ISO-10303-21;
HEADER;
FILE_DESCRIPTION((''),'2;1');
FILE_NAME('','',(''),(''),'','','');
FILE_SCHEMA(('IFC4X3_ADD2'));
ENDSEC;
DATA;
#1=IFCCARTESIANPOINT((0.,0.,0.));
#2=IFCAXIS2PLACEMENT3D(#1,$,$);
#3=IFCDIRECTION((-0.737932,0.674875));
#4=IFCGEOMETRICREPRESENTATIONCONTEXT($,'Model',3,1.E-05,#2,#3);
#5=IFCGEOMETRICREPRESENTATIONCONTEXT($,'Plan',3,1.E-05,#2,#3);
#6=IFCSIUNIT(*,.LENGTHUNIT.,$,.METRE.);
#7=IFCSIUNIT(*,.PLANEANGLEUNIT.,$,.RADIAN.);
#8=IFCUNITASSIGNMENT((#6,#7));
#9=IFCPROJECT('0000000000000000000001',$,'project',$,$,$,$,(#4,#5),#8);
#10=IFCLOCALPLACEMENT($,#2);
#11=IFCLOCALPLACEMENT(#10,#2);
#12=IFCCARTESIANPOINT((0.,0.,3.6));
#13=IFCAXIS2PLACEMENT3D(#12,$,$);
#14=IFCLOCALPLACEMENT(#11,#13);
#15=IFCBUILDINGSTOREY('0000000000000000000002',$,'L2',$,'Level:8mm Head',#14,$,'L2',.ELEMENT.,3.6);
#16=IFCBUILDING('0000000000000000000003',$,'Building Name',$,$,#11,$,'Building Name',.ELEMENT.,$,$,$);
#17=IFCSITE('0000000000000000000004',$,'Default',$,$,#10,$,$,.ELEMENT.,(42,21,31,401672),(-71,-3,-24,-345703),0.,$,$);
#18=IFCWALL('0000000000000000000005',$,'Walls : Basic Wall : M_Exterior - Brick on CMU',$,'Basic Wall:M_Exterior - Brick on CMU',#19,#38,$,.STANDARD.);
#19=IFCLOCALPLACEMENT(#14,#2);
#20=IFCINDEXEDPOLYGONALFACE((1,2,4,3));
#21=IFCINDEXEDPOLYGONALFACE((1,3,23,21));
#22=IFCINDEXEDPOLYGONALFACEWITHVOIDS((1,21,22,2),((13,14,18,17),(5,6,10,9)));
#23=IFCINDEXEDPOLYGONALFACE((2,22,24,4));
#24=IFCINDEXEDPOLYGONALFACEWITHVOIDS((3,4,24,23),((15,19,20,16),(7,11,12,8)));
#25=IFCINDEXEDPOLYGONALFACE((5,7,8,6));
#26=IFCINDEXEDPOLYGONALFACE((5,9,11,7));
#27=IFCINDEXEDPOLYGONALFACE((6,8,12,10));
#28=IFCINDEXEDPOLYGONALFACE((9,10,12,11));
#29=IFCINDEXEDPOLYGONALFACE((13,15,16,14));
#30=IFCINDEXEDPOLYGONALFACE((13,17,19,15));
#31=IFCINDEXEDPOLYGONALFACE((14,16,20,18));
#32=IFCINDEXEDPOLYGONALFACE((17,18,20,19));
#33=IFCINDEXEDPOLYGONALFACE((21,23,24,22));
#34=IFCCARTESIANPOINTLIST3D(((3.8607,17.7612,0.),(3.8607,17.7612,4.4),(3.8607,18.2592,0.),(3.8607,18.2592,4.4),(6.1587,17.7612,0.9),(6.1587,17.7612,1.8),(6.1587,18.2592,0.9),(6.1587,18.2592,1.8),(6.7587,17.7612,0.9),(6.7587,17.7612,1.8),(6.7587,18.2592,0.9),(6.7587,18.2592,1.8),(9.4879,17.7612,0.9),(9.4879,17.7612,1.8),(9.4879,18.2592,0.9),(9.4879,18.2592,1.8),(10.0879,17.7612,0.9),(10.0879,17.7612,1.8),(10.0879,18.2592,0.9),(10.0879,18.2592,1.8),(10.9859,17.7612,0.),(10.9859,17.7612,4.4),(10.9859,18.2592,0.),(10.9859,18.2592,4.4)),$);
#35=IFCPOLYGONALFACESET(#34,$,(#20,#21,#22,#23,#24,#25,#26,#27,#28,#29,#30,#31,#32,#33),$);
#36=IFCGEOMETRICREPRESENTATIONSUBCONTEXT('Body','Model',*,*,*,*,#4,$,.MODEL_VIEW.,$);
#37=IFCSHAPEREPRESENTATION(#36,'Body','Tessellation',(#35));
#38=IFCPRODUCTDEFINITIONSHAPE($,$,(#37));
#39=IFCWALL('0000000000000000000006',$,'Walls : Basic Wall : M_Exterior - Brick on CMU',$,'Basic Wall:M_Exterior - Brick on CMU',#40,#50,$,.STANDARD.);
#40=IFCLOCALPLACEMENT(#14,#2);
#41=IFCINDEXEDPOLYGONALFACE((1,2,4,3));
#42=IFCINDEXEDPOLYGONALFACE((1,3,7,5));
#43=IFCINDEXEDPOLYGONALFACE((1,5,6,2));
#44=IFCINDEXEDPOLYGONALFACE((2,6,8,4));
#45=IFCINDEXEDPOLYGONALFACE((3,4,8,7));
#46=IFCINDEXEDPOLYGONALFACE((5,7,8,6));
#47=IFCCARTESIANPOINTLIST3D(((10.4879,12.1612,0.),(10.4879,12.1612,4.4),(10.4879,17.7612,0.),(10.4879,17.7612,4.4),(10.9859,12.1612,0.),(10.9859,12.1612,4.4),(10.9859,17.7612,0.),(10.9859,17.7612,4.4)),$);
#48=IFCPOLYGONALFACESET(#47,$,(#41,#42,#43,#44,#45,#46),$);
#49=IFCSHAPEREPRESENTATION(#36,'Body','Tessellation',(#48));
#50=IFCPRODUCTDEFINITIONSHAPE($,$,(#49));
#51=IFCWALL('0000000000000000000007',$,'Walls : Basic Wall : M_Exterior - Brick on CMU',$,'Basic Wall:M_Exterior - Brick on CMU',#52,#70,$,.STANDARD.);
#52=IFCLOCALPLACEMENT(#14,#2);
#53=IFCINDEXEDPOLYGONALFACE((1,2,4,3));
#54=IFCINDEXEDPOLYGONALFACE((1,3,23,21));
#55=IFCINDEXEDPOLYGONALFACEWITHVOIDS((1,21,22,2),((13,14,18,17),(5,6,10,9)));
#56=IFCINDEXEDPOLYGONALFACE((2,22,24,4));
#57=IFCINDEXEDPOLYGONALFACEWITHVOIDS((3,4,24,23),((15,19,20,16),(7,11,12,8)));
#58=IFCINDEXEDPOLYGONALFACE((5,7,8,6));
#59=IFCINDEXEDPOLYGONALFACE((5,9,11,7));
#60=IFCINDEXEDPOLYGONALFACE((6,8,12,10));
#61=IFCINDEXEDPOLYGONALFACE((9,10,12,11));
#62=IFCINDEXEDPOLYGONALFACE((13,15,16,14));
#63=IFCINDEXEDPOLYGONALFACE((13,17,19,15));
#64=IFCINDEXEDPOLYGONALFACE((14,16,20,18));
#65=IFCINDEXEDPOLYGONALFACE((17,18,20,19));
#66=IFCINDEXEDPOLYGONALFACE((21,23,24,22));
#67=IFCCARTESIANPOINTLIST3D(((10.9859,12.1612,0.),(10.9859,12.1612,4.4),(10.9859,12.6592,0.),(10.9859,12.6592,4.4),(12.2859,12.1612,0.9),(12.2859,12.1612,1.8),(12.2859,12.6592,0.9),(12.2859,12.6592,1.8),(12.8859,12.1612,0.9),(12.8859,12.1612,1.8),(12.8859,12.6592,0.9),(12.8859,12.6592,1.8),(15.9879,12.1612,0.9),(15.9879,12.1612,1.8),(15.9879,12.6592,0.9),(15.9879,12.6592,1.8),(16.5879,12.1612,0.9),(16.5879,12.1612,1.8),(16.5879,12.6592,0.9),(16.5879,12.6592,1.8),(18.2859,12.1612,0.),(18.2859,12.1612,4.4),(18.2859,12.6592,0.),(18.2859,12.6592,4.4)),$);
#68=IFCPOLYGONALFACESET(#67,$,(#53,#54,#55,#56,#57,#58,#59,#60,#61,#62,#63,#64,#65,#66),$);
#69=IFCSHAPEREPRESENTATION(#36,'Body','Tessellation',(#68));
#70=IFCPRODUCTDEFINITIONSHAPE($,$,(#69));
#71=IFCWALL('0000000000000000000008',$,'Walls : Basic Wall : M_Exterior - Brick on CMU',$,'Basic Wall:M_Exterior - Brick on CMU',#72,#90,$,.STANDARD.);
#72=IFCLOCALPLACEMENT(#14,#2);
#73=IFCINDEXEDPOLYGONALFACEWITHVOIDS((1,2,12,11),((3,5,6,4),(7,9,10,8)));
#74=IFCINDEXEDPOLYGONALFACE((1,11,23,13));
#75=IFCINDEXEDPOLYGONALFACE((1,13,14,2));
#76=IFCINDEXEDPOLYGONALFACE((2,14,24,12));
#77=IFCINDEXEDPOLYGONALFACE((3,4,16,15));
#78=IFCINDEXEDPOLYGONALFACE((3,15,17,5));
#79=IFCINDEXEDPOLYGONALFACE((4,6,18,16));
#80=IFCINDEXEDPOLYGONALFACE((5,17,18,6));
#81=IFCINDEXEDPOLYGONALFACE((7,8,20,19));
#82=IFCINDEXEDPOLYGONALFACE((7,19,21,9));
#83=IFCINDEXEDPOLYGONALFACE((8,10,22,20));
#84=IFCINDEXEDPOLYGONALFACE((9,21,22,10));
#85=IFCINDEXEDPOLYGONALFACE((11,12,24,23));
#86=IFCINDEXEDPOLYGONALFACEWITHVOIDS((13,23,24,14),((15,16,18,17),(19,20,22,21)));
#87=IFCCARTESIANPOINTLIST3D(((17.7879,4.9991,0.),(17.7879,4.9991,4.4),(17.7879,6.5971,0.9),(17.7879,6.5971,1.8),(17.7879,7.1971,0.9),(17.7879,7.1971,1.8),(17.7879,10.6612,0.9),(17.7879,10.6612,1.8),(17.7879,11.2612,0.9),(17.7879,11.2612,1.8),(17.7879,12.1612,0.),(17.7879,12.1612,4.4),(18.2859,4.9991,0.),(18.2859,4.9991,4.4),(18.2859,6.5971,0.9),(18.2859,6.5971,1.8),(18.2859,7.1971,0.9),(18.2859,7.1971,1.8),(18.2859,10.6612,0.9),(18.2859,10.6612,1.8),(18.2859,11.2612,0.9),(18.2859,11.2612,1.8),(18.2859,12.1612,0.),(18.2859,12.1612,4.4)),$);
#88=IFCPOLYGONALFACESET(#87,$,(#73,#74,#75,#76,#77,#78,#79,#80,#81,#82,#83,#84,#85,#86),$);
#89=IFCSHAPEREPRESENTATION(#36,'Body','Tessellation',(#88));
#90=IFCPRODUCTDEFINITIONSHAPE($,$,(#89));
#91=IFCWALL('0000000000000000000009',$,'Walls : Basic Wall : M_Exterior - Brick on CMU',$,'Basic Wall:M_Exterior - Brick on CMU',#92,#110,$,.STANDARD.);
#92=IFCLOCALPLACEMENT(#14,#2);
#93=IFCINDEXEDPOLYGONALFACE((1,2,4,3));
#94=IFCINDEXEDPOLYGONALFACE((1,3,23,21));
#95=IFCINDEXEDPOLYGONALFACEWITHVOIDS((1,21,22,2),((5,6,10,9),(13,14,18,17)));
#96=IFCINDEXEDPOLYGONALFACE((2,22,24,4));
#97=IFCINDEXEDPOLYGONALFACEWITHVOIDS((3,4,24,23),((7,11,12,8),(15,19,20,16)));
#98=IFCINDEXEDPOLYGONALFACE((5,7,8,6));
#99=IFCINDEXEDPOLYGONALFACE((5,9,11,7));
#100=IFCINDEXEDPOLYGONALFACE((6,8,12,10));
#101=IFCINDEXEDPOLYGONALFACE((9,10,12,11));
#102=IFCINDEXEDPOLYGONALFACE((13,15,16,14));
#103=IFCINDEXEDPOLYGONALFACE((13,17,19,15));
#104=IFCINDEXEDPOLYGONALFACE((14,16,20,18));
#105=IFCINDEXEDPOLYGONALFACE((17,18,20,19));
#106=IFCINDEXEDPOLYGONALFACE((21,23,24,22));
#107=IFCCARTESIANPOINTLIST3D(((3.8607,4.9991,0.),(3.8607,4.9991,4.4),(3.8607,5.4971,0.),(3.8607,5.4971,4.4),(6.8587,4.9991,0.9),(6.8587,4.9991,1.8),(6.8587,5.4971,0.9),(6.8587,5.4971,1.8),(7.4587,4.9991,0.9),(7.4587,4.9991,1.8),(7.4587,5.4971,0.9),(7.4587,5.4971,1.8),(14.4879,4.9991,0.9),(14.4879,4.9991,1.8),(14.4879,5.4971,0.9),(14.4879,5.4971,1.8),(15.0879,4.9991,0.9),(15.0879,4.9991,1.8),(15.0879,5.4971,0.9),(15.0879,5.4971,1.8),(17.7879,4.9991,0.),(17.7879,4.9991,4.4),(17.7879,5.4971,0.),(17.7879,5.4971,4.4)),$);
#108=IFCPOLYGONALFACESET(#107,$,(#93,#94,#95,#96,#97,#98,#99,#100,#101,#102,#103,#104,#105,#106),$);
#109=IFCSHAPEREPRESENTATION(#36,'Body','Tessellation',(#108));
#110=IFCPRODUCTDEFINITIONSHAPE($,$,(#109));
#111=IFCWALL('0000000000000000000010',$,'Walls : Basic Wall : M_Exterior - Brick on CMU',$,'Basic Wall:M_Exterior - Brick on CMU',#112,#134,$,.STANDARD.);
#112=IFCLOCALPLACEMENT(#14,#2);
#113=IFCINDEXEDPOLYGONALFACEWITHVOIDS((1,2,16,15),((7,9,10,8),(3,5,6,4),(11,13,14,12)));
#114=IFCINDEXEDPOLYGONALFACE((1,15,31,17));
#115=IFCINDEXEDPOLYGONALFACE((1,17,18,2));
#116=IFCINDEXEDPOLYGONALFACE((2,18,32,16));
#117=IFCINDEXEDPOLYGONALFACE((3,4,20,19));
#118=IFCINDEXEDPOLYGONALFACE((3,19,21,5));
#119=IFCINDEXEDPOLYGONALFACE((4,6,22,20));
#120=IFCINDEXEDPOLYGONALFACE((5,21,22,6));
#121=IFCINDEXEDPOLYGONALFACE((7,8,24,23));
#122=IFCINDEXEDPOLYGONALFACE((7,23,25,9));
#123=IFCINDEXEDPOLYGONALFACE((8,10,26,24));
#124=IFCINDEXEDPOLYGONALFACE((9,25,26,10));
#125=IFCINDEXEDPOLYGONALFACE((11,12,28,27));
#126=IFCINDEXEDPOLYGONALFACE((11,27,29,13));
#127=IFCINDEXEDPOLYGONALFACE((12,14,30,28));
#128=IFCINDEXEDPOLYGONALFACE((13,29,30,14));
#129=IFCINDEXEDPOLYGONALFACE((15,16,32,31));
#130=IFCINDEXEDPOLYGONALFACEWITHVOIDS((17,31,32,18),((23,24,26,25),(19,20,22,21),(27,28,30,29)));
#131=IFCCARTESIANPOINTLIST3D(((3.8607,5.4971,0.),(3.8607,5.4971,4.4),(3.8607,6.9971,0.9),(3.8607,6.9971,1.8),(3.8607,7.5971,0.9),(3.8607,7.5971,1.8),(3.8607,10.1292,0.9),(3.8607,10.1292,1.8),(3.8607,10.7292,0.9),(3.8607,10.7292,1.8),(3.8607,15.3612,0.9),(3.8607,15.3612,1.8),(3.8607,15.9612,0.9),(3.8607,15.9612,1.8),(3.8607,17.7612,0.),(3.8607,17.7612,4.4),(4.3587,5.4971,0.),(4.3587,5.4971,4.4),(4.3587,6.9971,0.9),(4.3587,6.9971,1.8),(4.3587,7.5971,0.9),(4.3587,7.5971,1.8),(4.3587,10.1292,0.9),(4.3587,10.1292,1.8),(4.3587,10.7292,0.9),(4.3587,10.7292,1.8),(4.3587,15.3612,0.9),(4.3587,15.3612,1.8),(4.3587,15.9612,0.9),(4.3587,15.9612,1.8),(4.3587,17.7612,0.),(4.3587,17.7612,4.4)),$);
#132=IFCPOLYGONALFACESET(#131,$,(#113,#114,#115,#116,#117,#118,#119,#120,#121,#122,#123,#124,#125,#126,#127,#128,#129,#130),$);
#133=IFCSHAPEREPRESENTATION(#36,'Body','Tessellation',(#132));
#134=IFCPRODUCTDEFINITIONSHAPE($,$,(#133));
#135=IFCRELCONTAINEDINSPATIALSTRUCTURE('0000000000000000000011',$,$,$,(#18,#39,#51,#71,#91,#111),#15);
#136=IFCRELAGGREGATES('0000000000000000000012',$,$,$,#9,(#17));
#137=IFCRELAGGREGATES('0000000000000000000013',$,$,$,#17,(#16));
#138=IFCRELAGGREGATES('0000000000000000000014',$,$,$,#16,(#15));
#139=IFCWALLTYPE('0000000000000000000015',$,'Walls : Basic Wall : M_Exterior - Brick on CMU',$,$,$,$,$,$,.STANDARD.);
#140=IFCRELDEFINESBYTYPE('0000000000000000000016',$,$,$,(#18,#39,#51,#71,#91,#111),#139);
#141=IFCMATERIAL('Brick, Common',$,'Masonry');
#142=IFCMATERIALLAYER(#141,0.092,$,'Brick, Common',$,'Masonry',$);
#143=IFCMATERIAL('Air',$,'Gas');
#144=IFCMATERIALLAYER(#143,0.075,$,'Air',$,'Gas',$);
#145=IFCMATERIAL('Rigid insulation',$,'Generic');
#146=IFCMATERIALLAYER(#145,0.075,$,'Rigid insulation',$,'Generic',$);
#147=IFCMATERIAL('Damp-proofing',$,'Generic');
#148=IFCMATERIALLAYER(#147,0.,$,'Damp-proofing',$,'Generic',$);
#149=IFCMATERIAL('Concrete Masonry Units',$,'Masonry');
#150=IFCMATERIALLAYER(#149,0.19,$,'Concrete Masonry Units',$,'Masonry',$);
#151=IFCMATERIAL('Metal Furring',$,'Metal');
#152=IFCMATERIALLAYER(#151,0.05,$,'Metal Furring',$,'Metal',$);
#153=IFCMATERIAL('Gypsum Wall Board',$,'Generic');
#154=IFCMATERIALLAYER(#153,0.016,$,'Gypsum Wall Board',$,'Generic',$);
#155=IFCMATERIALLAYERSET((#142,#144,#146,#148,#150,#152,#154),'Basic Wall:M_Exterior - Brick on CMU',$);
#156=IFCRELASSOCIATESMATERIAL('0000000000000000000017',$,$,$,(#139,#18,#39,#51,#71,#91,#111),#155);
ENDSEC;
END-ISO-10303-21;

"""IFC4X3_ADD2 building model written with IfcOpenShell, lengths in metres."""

from ifc_helpers import new_model, si_unit, direction, frame, frame_2d, origin, place, context, subcontext, project, spatial, rectangle, extrude, material, layer, layer_set, type_object, element, save


model = new_model("IFC4X3_ADD2")

# Units and contexts
model_context = context("Model", 3, precision=1e-05, world=origin(), true_north=direction((-0.737932, 0.674875)))
plan_context = context("Plan", 3, precision=1e-05, world=origin(), true_north=direction((-0.737932, 0.674875)))
body_context = subcontext(model_context, "Body", "Model", "MODEL_VIEW")
ifc_project = project(units=[si_unit("LENGTHUNIT", "METRE"), si_unit("PLANEANGLEUNIT", "RADIAN")], contexts=[model_context, plan_context])

# Site, building, storey
site_placement = place(None, origin())
site = spatial("IfcSite", under=ifc_project, at=site_placement, Name="Default", CompositionType="ELEMENT", RefLatitude=(42, 21, 31, 401672), RefLongitude=(-71, -3, -24, -345703), RefElevation=0.0)
building_placement = place(site_placement, origin())
building = spatial("IfcBuilding", under=site, at=building_placement, Name="Building Name", LongName="Building Name", CompositionType="ELEMENT")
storey_placement = place(building_placement, frame((0.0, 0.0, 3.6)))
storey = spatial("IfcBuildingStorey", under=building, at=storey_placement, Name="L2", ObjectType="Level:8mm Head", LongName="L2", CompositionType="ELEMENT", Elevation=3.6)

# Wall, openings
ifc_material_1 = material(Name="Brick, Common", Category="Masonry")
ifc_layer_1 = layer(ifc_material_1, 0.092, Name="Brick, Common", Category="Masonry")
ifc_material_2 = material(Name="Air", Category="Gas")
ifc_layer_2 = layer(ifc_material_2, 0.075, Name="Air", Category="Gas")
ifc_material_3 = material(Name="Rigid insulation", Category="Generic")
ifc_layer_3 = layer(ifc_material_3, 0.075, Name="Rigid insulation", Category="Generic")
ifc_material_4 = material(Name="Damp-proofing", Category="Generic")
ifc_layer_4 = layer(ifc_material_4, 0.0, Name="Damp-proofing", Category="Generic")
ifc_material_5 = material(Name="Concrete Masonry Units", Category="Masonry")
ifc_layer_5 = layer(ifc_material_5, 0.19, Name="Concrete Masonry Units", Category="Masonry")
ifc_material_6 = material(Name="Metal Furring", Category="Metal")
ifc_layer_6 = layer(ifc_material_6, 0.05, Name="Metal Furring", Category="Metal")
ifc_material_7 = material(Name="Gypsum Wall Board", Category="Generic")
ifc_layer_7 = layer(ifc_material_7, 0.016, Name="Gypsum Wall Board", Category="Generic")
ifc_layer_set = layer_set([ifc_layer_1, ifc_layer_2, ifc_layer_3, ifc_layer_4, ifc_layer_5, ifc_layer_6, ifc_layer_7], Name="Basic Wall:M_Exterior - Brick on CMU")
wall_type = type_object("IfcWallType", Name="Walls : Basic Wall : M_Exterior - Brick on CMU", PredefinedType="STANDARD", material=ifc_layer_set)
wall_1_placement = place(storey_placement, frame((3.8607, 18.0102, 0.0)))
wall_1 = element("IfcWall", 1, at=wall_1_placement, inside=storey, type_object=wall_type, material=ifc_layer_set, Name="Walls : Basic Wall : M_Exterior - Brick on CMU", ObjectType="Basic Wall:M_Exterior - Brick on CMU", PredefinedType="STANDARD", context=body_context, shape_type="SweptSolid", body=[
    extrude(rectangle(XDim=7.1251, YDim=0.498, at=frame_2d((3.5626, 0.0), x_axis=(-1.0, 0.0))), origin(), (0.0, 0.0, 1.0), 4.4),
])
opening_1_placement = place(wall_1_placement, frame((-3.8607, -18.0102, 0.9)))
element("IfcOpeningElement", 2, at=opening_1_placement, cuts=wall_1, PredefinedType="OPENING", context=body_context, shape_type="SweptSolid", body=[
    extrude(rectangle(XDim=0.9, YDim=0.6, at=frame_2d((0.0, 0.0), x_axis=(1.0, 0.0))), frame((9.7879, 16.2372, 0.45), z_axis=(0.0, 1.0, 0.0), x_axis=(0.0, 0.0, -1.0)), (0.0, 0.0, 1.0), 3.048),
])
opening_2_placement = place(wall_1_placement, frame((-3.8607, -18.0102, 0.9)))
element("IfcOpeningElement", 3, at=opening_2_placement, cuts=wall_1, PredefinedType="OPENING", context=body_context, shape_type="SweptSolid", body=[
    extrude(rectangle(XDim=0.9, YDim=0.6, at=frame_2d((0.0, 0.0), x_axis=(1.0, 0.0))), frame((6.4587, 16.2372, 0.45), z_axis=(0.0, 1.0, 0.0), x_axis=(0.0, 0.0, -1.0)), (0.0, 0.0, 1.0), 3.048),
])

# Wall
wall_2_placement = place(storey_placement, frame((10.7369, 17.7612, 0.0), z_axis=(0.0, 0.0, 1.0), x_axis=(0.0, -1.0, 0.0)))
element("IfcWall", 4, at=wall_2_placement, inside=storey, type_object=wall_type, material=ifc_layer_set, Name="Walls : Basic Wall : M_Exterior - Brick on CMU", ObjectType="Basic Wall:M_Exterior - Brick on CMU", PredefinedType="STANDARD", context=body_context, shape_type="SweptSolid", body=[
    extrude(rectangle(XDim=5.6, YDim=0.498, at=frame_2d((2.8, 0.0), x_axis=(-1.0, 0.0))), origin(), (0.0, 0.0, 1.0), 4.4),
])

# Walls, openings
wall_3_placement = place(storey_placement, frame((10.9859, 12.4102, 0.0)))
wall_3 = element("IfcWall", 5, at=wall_3_placement, inside=storey, type_object=wall_type, material=ifc_layer_set, Name="Walls : Basic Wall : M_Exterior - Brick on CMU", ObjectType="Basic Wall:M_Exterior - Brick on CMU", PredefinedType="STANDARD", context=body_context, shape_type="SweptSolid", body=[
    extrude(rectangle(XDim=7.3, YDim=0.498, at=frame_2d((3.65, 0.0), x_axis=(-1.0, 0.0))), origin(), (0.0, 0.0, 1.0), 4.4),
])
opening_3_placement = place(wall_3_placement, frame((-10.9859, -12.4102, 0.9)))
element("IfcOpeningElement", 6, at=opening_3_placement, cuts=wall_3, PredefinedType="OPENING", context=body_context, shape_type="SweptSolid", body=[
    extrude(rectangle(XDim=0.9, YDim=0.6, at=frame_2d((0.0, 0.0), x_axis=(1.0, 0.0))), frame((16.2879, 10.6372, 0.45), z_axis=(0.0, 1.0, 0.0), x_axis=(0.0, 0.0, -1.0)), (0.0, 0.0, 1.0), 3.048),
])
opening_4_placement = place(wall_3_placement, frame((-10.9859, -12.4102, 0.9)))
element("IfcOpeningElement", 7, at=opening_4_placement, cuts=wall_3, PredefinedType="OPENING", context=body_context, shape_type="SweptSolid", body=[
    extrude(rectangle(XDim=0.9, YDim=0.6, at=frame_2d((0.0, 0.0), x_axis=(1.0, 0.0))), frame((12.5859, 10.6372, 0.45), z_axis=(0.0, 1.0, 0.0), x_axis=(0.0, 0.0, -1.0)), (0.0, 0.0, 1.0), 3.048),
])
wall_4_placement = place(storey_placement, frame((18.0369, 12.1612, 0.0), z_axis=(0.0, 0.0, 1.0), x_axis=(0.0, -1.0, 0.0)))
wall_4 = element("IfcWall", 8, at=wall_4_placement, inside=storey, type_object=wall_type, material=ifc_layer_set, Name="Walls : Basic Wall : M_Exterior - Brick on CMU", ObjectType="Basic Wall:M_Exterior - Brick on CMU", PredefinedType="STANDARD", context=body_context, shape_type="SweptSolid", body=[
    extrude(rectangle(XDim=7.1621, YDim=0.498, at=frame_2d((3.581, 0.0), x_axis=(-1.0, 0.0))), origin(), (0.0, 0.0, 1.0), 4.4),
])
opening_5_placement = place(wall_4_placement, frame((12.1612, -18.0369, 0.9)))
element("IfcOpeningElement", 9, at=opening_5_placement, cuts=wall_4, PredefinedType="OPENING", context=body_context, shape_type="SweptSolid", body=[
    extrude(rectangle(XDim=0.9, YDim=0.6, at=frame_2d((0.0, 0.0), x_axis=(1.0, 0.0))), frame((-6.8971, 16.2639, 0.45), z_axis=(0.0, 1.0, 0.0), x_axis=(0.0, 0.0, -1.0)), (0.0, 0.0, 1.0), 3.048),
])
opening_6_placement = place(wall_4_placement, frame((12.1612, -18.0369, 0.9)))
element("IfcOpeningElement", 10, at=opening_6_placement, cuts=wall_4, PredefinedType="OPENING", context=body_context, shape_type="SweptSolid", body=[
    extrude(rectangle(XDim=0.9, YDim=0.6, at=frame_2d((0.0, 0.0), x_axis=(1.0, 0.0))), frame((-10.9612, 16.2639, 0.45), z_axis=(0.0, 1.0, 0.0), x_axis=(0.0, 0.0, -1.0)), (0.0, 0.0, 1.0), 3.048),
])
wall_5_placement = place(storey_placement, frame((17.7879, 5.2481, 0.0), z_axis=(0.0, 0.0, 1.0), x_axis=(-1.0, 0.0, 0.0)))
wall_5 = element("IfcWall", 11, at=wall_5_placement, inside=storey, type_object=wall_type, material=ifc_layer_set, Name="Walls : Basic Wall : M_Exterior - Brick on CMU", ObjectType="Basic Wall:M_Exterior - Brick on CMU", PredefinedType="STANDARD", context=body_context, shape_type="SweptSolid", body=[
    extrude(rectangle(XDim=13.9271, YDim=0.498, at=frame_2d((6.9636, 0.0), x_axis=(-1.0, 0.0))), origin(), (0.0, 0.0, 1.0), 4.4),
])
opening_7_placement = place(wall_5_placement, frame((17.7879, 5.2481, 0.9)))
element("IfcOpeningElement", 12, at=opening_7_placement, cuts=wall_5, PredefinedType="OPENING", context=body_context, shape_type="SweptSolid", body=[
    extrude(rectangle(XDim=0.9, YDim=0.6, at=frame_2d((0.0, 0.0), x_axis=(1.0, 0.0))), frame((-7.1587, -7.0211, 0.45), z_axis=(0.0, 1.0, 0.0), x_axis=(0.0, 0.0, -1.0)), (0.0, 0.0, 1.0), 3.048),
])
opening_8_placement = place(wall_5_placement, frame((17.7879, 5.2481, 0.9)))
element("IfcOpeningElement", 13, at=opening_8_placement, cuts=wall_5, PredefinedType="OPENING", context=body_context, shape_type="SweptSolid", body=[
    extrude(rectangle(XDim=0.9, YDim=0.6, at=frame_2d((0.0, 0.0), x_axis=(1.0, 0.0))), frame((-14.7879, -7.0211, 0.45), z_axis=(0.0, 1.0, 0.0), x_axis=(0.0, 0.0, -1.0)), (0.0, 0.0, 1.0), 3.048),
])
wall_6_placement = place(storey_placement, frame((4.1097, 5.4971, 0.0), z_axis=(0.0, 0.0, 1.0), x_axis=(0.0, 1.0, 0.0)))
wall_6 = element("IfcWall", 14, at=wall_6_placement, inside=storey, type_object=wall_type, material=ifc_layer_set, Name="Walls : Basic Wall : M_Exterior - Brick on CMU", ObjectType="Basic Wall:M_Exterior - Brick on CMU", PredefinedType="STANDARD", context=body_context, shape_type="SweptSolid", body=[
    extrude(rectangle(XDim=12.2641, YDim=0.498, at=frame_2d((6.132, 0.0), x_axis=(-1.0, 0.0))), origin(), (0.0, 0.0, 1.0), 4.4),
])
opening_9_placement = place(wall_6_placement, frame((-5.4971, 4.1097, 0.9)))
element("IfcOpeningElement", 15, at=opening_9_placement, cuts=wall_6, PredefinedType="OPENING", context=body_context, shape_type="SweptSolid", body=[
    extrude(rectangle(XDim=0.9, YDim=0.6, at=frame_2d((0.0, 0.0), x_axis=(1.0, 0.0))), frame((15.6612, -5.8827, 0.45), z_axis=(0.0, 1.0, 0.0), x_axis=(0.0, 0.0, -1.0)), (0.0, 0.0, 1.0), 3.048),
])
opening_10_placement = place(wall_6_placement, frame((-5.4971, 4.1097, 0.9)))
element("IfcOpeningElement", 16, at=opening_10_placement, cuts=wall_6, PredefinedType="OPENING", context=body_context, shape_type="SweptSolid", body=[
    extrude(rectangle(XDim=0.9, YDim=0.6, at=frame_2d((0.0, 0.0), x_axis=(1.0, 0.0))), frame((10.4292, -5.8827, 0.45), z_axis=(0.0, 1.0, 0.0), x_axis=(0.0, 0.0, -1.0)), (0.0, 0.0, 1.0), 3.048),
])
opening_11_placement = place(wall_6_placement, frame((-5.4971, 4.1097, 0.9)))
element("IfcOpeningElement", 17, at=opening_11_placement, cuts=wall_6, PredefinedType="OPENING", context=body_context, shape_type="SweptSolid", body=[
    extrude(rectangle(XDim=0.9, YDim=0.6, at=frame_2d((0.0, 0.0), x_axis=(1.0, 0.0))), frame((7.2971, -5.8827, 0.45), z_axis=(0.0, 1.0, 0.0), x_axis=(0.0, 0.0, -1.0)), (0.0, 0.0, 1.0), 3.048),
])

save(model, "model.ifc")
